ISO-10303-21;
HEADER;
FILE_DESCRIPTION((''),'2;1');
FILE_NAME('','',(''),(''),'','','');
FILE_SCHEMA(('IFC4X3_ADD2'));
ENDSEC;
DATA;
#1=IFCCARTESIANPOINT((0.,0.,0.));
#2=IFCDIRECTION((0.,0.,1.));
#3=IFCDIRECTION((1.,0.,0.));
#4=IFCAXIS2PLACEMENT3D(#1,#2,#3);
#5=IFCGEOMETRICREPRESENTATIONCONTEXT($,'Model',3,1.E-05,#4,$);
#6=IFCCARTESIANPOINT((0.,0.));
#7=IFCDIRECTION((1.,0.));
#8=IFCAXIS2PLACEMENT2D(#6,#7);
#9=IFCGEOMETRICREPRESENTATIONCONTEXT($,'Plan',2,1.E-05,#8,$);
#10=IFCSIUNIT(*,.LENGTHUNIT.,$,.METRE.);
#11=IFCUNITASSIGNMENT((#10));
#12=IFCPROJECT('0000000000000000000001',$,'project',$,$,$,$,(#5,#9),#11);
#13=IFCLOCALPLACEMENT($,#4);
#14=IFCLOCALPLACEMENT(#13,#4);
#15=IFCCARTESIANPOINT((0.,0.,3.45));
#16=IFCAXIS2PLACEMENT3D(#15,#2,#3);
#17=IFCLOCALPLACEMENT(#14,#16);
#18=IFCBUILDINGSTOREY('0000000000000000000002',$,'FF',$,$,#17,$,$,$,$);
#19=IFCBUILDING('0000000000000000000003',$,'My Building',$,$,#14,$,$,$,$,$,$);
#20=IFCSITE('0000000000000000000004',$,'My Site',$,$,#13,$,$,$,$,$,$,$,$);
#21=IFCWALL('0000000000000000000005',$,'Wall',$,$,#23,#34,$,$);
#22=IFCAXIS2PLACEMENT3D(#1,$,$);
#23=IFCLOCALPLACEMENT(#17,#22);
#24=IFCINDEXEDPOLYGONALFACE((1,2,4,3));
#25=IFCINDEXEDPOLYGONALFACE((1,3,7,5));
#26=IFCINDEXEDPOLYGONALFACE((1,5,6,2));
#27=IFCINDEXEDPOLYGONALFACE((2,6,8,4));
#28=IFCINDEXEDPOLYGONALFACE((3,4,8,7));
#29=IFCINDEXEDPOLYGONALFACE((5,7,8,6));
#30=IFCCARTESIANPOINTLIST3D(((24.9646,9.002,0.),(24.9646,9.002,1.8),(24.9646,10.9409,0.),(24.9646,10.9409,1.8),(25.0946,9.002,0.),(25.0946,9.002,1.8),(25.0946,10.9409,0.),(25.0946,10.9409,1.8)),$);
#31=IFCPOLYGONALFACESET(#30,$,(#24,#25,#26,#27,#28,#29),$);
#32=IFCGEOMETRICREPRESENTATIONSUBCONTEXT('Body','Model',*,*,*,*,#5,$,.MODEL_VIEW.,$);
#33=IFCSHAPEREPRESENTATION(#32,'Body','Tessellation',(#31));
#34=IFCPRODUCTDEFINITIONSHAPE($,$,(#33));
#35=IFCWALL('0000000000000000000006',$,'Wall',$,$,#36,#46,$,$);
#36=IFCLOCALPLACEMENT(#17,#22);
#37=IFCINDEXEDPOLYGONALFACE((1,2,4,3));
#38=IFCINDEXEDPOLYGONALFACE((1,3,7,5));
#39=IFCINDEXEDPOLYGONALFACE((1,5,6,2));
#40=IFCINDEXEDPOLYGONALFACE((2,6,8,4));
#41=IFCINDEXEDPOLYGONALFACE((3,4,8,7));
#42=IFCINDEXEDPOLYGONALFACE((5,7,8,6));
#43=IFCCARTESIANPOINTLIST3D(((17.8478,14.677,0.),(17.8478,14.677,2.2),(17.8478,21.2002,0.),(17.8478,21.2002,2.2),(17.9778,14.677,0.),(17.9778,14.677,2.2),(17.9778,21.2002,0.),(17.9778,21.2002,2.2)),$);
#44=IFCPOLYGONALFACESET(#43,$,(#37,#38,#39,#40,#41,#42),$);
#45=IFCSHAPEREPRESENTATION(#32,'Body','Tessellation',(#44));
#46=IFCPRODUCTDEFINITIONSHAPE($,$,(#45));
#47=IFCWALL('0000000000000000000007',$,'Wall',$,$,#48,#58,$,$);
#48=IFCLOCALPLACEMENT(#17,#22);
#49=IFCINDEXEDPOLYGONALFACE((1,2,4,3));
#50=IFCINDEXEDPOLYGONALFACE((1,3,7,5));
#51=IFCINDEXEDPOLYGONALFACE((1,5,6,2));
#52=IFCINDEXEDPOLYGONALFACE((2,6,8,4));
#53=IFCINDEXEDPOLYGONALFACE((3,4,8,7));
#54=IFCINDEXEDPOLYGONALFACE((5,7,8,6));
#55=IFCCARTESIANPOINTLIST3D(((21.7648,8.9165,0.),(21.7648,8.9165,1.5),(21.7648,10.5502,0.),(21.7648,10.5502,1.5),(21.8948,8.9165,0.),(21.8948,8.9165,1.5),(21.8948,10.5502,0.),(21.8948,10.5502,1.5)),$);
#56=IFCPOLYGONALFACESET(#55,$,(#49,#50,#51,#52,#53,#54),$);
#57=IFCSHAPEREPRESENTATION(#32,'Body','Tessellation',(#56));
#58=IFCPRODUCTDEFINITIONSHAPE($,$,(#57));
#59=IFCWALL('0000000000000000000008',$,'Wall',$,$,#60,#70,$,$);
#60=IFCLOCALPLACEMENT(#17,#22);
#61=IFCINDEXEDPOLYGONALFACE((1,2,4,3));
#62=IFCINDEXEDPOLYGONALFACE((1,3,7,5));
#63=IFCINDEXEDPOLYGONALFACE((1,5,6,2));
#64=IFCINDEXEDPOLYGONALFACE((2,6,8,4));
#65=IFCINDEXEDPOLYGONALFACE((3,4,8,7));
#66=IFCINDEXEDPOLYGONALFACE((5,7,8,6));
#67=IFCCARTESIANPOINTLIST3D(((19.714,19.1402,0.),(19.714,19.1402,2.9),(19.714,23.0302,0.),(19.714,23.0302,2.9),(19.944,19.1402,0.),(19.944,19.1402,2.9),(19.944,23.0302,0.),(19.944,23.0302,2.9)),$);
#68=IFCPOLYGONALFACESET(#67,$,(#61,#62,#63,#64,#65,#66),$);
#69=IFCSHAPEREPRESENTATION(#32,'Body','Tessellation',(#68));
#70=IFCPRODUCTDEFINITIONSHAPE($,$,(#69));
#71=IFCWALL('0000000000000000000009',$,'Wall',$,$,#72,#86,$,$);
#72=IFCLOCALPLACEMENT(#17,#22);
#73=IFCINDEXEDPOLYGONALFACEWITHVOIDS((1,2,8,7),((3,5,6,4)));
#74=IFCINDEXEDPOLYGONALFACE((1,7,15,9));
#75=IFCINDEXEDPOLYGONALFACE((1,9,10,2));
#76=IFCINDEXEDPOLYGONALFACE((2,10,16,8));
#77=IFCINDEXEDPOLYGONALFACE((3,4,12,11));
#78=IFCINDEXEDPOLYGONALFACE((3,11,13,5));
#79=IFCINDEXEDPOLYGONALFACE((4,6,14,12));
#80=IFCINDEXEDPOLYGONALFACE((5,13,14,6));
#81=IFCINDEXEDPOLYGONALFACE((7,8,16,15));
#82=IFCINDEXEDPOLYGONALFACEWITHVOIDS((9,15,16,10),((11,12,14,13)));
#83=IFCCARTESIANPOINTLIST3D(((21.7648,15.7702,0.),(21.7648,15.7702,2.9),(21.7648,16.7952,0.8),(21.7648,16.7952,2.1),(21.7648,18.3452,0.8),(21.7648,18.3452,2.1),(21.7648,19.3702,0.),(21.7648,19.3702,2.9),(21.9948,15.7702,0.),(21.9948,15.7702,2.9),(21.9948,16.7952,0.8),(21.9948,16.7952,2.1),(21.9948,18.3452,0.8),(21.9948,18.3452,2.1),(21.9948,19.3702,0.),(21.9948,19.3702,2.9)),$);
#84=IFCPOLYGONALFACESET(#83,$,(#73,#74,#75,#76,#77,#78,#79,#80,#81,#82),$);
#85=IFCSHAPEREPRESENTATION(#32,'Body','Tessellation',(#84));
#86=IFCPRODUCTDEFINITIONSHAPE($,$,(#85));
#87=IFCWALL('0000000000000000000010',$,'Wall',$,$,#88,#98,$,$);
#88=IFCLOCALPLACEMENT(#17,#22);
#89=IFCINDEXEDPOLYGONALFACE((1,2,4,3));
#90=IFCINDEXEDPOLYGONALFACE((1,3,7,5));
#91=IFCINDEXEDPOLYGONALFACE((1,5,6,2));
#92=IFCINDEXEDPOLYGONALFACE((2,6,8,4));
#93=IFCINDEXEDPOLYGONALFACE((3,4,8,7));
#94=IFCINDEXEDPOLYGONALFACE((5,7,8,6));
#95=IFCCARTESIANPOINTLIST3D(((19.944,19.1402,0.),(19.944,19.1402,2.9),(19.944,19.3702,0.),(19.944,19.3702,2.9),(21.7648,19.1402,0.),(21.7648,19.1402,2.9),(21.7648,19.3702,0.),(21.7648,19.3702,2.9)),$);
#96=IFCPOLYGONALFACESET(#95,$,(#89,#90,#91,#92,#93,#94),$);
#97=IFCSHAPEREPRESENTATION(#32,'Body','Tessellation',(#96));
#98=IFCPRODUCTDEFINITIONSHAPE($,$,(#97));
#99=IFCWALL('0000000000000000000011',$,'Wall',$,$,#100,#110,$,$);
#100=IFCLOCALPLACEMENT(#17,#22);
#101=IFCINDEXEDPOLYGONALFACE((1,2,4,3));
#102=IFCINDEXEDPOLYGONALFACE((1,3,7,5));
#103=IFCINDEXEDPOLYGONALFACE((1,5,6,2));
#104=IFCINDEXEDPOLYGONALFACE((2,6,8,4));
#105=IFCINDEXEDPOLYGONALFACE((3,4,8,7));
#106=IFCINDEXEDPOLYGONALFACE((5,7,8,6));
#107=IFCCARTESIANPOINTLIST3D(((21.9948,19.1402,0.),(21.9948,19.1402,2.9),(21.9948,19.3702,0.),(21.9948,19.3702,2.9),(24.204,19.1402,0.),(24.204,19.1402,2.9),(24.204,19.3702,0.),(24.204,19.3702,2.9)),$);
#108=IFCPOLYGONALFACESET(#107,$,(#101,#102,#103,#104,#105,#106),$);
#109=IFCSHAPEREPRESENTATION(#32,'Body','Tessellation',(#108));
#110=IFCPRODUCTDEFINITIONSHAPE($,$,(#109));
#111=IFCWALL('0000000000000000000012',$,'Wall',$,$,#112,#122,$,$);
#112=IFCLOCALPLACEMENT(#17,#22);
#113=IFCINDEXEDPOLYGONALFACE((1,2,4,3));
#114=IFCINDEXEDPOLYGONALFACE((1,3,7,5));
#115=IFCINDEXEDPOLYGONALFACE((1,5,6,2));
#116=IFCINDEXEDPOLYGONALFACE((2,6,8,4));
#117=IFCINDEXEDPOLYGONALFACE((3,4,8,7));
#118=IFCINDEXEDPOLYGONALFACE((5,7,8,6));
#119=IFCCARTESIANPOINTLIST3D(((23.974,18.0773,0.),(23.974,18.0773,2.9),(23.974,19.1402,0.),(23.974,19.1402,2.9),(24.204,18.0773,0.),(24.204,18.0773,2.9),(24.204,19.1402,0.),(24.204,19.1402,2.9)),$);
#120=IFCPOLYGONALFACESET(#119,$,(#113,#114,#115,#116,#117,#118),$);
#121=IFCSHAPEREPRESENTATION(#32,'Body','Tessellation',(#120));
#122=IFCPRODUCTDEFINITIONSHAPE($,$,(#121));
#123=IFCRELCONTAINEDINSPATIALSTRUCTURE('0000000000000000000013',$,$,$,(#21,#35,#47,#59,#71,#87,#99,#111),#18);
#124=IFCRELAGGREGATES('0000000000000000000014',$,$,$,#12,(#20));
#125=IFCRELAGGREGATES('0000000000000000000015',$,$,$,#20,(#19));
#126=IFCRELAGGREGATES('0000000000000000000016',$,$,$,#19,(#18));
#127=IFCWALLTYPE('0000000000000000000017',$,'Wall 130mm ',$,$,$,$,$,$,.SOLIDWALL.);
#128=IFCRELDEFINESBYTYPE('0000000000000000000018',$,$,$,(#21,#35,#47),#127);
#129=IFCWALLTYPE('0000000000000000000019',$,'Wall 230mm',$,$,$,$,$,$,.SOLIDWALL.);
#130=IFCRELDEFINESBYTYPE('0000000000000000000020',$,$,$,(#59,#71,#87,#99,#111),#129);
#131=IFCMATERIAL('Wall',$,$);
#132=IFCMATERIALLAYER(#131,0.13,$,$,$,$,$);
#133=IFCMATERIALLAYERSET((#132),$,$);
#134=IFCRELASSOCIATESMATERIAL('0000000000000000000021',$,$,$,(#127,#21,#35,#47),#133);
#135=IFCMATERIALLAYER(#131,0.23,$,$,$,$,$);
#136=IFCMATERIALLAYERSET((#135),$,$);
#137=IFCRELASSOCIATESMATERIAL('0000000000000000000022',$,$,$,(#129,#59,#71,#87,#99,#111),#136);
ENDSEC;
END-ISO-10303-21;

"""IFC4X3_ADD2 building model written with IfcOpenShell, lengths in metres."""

from ifc_helpers import new_model, si_unit, frame, origin_with_axes, origin_2d_with_axis, place, context, subcontext, project, spatial, line, indexed_curve, outline, extrude, source, transform, mapped, material, layer, layer_set, layer_usage, type_object, element, save


model = new_model("IFC4X3_ADD2")

# Units and contexts
model_context = context("Model", 3, precision=1e-05, world=origin_with_axes())
plan_context = context("Plan", 2, precision=1e-05, world=origin_2d_with_axis())
body_context_1 = subcontext(model_context, "Body", "Model", "MODEL_VIEW")
ifc_project = project(units=[si_unit("LENGTHUNIT", "METRE")], contexts=[model_context, plan_context])

# Site, building, storey
site_placement = place(None, origin_with_axes())
site = spatial("IfcSite", under=ifc_project, at=site_placement, Name="My Site")
building_placement = place(site_placement, origin_with_axes())
building = spatial("IfcBuilding", under=site, at=building_placement, Name="My Building")
storey_placement = place(building_placement, frame((0.0, 0.0, 3.45), z_axis=(0.0, 0.0, 1.0), x_axis=(1.0, 0.0, 0.0)))
storey = spatial("IfcBuildingStorey", under=building, at=storey_placement, Name="FF")

# Shared definitions
ifc_material_1 = material(Name="Wall")
ifc_layer_1 = layer(ifc_material_1, 0.13)
ifc_layer_set_1 = layer_set([ifc_layer_1])
wall_type_1 = type_object("IfcWallType", Name="Wall 130mm ", PredefinedType="SOLIDWALL", material=ifc_layer_set_1)

# Walls
ifc_layer_usage_1 = layer_usage(ifc_layer_set_1, "AXIS2", "POSITIVE", 0.0)
wall_1_placement = place(storey_placement, frame((25.0946, 9.002, 0.0), z_axis=(0.0, 0.0, 1.0), x_axis=(0.0, 1.0, 0.0)))
element("IfcWall", 1, at=wall_1_placement, inside=storey, type_object=wall_type_1, material=ifc_layer_usage_1, Name="Wall", context=body_context_1, shape_type="SweptSolid", body=[
    extrude(outline(indexed_curve([(0.0, 0.0), (0.0, 0.13), (1.9389, 0.13), (1.9389, 0.0), (0.0, 0.0)], self_intersect=False)), origin_with_axes(), (0.0, 0.0, 1.0), 1.8),
])
ifc_layer_usage_2 = layer_usage(ifc_layer_set_1, "AXIS2", "POSITIVE", 0.0)
wall_2_placement = place(storey_placement, frame((17.9778, 14.677, 0.0), z_axis=(0.0, 0.0, 1.0), x_axis=(0.000001, 1.0, 0.0)))
element("IfcWall", 2, at=wall_2_placement, inside=storey, type_object=wall_type_1, material=ifc_layer_usage_2, Name="Wall", context=body_context_1, shape_type="SweptSolid", body=[
    extrude(outline(indexed_curve([(0.0, 0.0), (0.0, 0.13), (6.5232, 0.13), (6.5232, 0.0), (0.0, 0.0)], self_intersect=False)), origin_with_axes(), (0.0, 0.0, 1.0), 2.2),
])
ifc_layer_usage_3 = layer_usage(ifc_layer_set_1, "AXIS2", "POSITIVE", 0.0)
wall_3_placement = place(storey_placement, frame((21.7648, 10.5502, 0.0), z_axis=(0.0, 0.0, 1.0), x_axis=(0.0, -1.0, 0.0)))
element("IfcWall", 3, at=wall_3_placement, inside=storey, type_object=wall_type_1, material=ifc_layer_usage_3, Name="Wall", context=body_context_1, shape_type="SweptSolid", body=[
    extrude(outline(indexed_curve([(0.0, 0.0), (0.0, 0.13), (1.6337, 0.13), (1.6337, 0.0), (0.0, 0.0)], self_intersect=False)), origin_with_axes(), (0.0, 0.0, 1.0), 1.5),
])
ifc_layer_2 = layer(ifc_material_1, 0.23)
ifc_layer_set_2 = layer_set([ifc_layer_2])
ifc_layer_usage_4 = layer_usage(ifc_layer_set_2, "AXIS2", "POSITIVE", 0.0)
wall_type_2 = type_object("IfcWallType", Name="Wall 230mm", PredefinedType="SOLIDWALL", material=ifc_layer_set_2)
wall_4_placement = place(storey_placement, frame((19.944, 19.1402, 0.0), z_axis=(0.0, 0.0, 1.0), x_axis=(0.000001, 1.0, 0.0)))
element("IfcWall", 4, at=wall_4_placement, inside=storey, type_object=wall_type_2, material=ifc_layer_usage_4, Name="Wall", context=body_context_1, shape_type="SweptSolid", body=[
    extrude(outline(indexed_curve([(0.0, 0.0), (0.0, 0.23), (3.89, 0.23), (3.89, 0.0), (0.0, 0.0)], self_intersect=False)), origin_with_axes(), (0.0, 0.0, 1.0), 2.9),
])

# Wall, opening
ifc_layer_usage_5 = layer_usage(ifc_layer_set_2, "AXIS2", "POSITIVE", 0.0)
wall_5_placement = place(storey_placement, frame((21.9948, 15.7702, 0.0), z_axis=(0.0, 0.0, 1.0), x_axis=(0.000001, 1.0, 0.0)))
wall_5 = element("IfcWall", 5, at=wall_5_placement, inside=storey, type_object=wall_type_2, material=ifc_layer_usage_5, Name="Wall", context=body_context_1, shape_type="SweptSolid", body=[
    extrude(outline(indexed_curve([(0.0, 0.0), (0.0, 0.23), (3.6, 0.23), (3.6, 0.0), (0.0, 0.0)], self_intersect=False)), origin_with_axes(), (0.0, 0.0, 1.0), 2.9),
])
shared_shape_1 = source(origin_with_axes(), body_context_1, "Body", "SweptSolid", [
    extrude(outline(indexed_curve([(0.0, 0.0), (1.55, 0.0), (1.55, 1.3), (0.0, 1.3)], segments=[line(1, 2, 3, 4, 1)])), frame((-0.775, -0.6, 0.0), z_axis=(0.0, -1.0, 0.0), x_axis=(1.0, 0.0, 0.0)), (0.0, 0.0, -1.0), 1.2),
])
opening_1_placement = place(wall_5_placement, frame((1.8, 0.0, 0.8), z_axis=(0.0, 0.0, 1.0), x_axis=(1.0, 0.0, 0.0)))
element("IfcOpeningElement", 6, at=opening_1_placement, cuts=wall_5, PredefinedType="OPENING", context=body_context_1, shape_type="MappedRepresentation", body=[
    mapped(shared_shape_1, transform((0.0, 0.0, 0.0), x_axis=(1.0, 0.0, 0.0), y_axis=(0.0, 1.0, 0.0), z_axis=(0.0, 0.0, 1.0), scale=1.0)),
])

# Walls
ifc_layer_usage_6 = layer_usage(ifc_layer_set_2, "AXIS2", "POSITIVE", 0.0)
wall_6_placement = place(storey_placement, frame((21.7648, 19.3702, 0.0), z_axis=(0.0, 0.0, 1.0), x_axis=(-1.0, 0.0, 0.0)))
element("IfcWall", 7, at=wall_6_placement, inside=storey, type_object=wall_type_2, material=ifc_layer_usage_6, Name="Wall", context=body_context_1, shape_type="SweptSolid", body=[
    extrude(outline(indexed_curve([(0.0, 0.0), (0.0, 0.23), (1.8208, 0.23), (1.8208, 0.0), (0.0, 0.0)], self_intersect=False)), origin_with_axes(), (0.0, 0.0, 1.0), 2.9),
])
ifc_layer_usage_7 = layer_usage(ifc_layer_set_2, "AXIS2", "POSITIVE", 0.0)
wall_7_placement = place(storey_placement, frame((24.204, 19.3702, 0.0), z_axis=(0.0, 0.0, 1.0), x_axis=(-1.0, 0.0, 0.0)))
element("IfcWall", 8, at=wall_7_placement, inside=storey, type_object=wall_type_2, material=ifc_layer_usage_7, Name="Wall", context=body_context_1, shape_type="SweptSolid", body=[
    extrude(outline(indexed_curve([(0.0, 0.0), (0.0, 0.23), (2.2092, 0.23), (2.2092, 0.0), (0.0, 0.0)], self_intersect=False)), origin_with_axes(), (0.0, 0.0, 1.0), 2.9),
])
ifc_layer_usage_8 = layer_usage(ifc_layer_set_2, "AXIS2", "POSITIVE", 0.0)
wall_8_placement = place(storey_placement, frame((24.204, 18.0773, 0.0), z_axis=(0.0, 0.0, 1.0), x_axis=(0.000001, 1.0, 0.0)))
element("IfcWall", 9, at=wall_8_placement, inside=storey, type_object=wall_type_2, material=ifc_layer_usage_8, Name="Wall", context=body_context_1, shape_type="SweptSolid", body=[
    extrude(outline(indexed_curve([(0.0, 0.0), (0.0, 0.23), (1.0629, 0.23), (1.0629, 0.0), (0.0, 0.0)], self_intersect=False)), origin_with_axes(), (0.0, 0.0, 1.0), 2.9),
])

save(model, "model.ifc")
